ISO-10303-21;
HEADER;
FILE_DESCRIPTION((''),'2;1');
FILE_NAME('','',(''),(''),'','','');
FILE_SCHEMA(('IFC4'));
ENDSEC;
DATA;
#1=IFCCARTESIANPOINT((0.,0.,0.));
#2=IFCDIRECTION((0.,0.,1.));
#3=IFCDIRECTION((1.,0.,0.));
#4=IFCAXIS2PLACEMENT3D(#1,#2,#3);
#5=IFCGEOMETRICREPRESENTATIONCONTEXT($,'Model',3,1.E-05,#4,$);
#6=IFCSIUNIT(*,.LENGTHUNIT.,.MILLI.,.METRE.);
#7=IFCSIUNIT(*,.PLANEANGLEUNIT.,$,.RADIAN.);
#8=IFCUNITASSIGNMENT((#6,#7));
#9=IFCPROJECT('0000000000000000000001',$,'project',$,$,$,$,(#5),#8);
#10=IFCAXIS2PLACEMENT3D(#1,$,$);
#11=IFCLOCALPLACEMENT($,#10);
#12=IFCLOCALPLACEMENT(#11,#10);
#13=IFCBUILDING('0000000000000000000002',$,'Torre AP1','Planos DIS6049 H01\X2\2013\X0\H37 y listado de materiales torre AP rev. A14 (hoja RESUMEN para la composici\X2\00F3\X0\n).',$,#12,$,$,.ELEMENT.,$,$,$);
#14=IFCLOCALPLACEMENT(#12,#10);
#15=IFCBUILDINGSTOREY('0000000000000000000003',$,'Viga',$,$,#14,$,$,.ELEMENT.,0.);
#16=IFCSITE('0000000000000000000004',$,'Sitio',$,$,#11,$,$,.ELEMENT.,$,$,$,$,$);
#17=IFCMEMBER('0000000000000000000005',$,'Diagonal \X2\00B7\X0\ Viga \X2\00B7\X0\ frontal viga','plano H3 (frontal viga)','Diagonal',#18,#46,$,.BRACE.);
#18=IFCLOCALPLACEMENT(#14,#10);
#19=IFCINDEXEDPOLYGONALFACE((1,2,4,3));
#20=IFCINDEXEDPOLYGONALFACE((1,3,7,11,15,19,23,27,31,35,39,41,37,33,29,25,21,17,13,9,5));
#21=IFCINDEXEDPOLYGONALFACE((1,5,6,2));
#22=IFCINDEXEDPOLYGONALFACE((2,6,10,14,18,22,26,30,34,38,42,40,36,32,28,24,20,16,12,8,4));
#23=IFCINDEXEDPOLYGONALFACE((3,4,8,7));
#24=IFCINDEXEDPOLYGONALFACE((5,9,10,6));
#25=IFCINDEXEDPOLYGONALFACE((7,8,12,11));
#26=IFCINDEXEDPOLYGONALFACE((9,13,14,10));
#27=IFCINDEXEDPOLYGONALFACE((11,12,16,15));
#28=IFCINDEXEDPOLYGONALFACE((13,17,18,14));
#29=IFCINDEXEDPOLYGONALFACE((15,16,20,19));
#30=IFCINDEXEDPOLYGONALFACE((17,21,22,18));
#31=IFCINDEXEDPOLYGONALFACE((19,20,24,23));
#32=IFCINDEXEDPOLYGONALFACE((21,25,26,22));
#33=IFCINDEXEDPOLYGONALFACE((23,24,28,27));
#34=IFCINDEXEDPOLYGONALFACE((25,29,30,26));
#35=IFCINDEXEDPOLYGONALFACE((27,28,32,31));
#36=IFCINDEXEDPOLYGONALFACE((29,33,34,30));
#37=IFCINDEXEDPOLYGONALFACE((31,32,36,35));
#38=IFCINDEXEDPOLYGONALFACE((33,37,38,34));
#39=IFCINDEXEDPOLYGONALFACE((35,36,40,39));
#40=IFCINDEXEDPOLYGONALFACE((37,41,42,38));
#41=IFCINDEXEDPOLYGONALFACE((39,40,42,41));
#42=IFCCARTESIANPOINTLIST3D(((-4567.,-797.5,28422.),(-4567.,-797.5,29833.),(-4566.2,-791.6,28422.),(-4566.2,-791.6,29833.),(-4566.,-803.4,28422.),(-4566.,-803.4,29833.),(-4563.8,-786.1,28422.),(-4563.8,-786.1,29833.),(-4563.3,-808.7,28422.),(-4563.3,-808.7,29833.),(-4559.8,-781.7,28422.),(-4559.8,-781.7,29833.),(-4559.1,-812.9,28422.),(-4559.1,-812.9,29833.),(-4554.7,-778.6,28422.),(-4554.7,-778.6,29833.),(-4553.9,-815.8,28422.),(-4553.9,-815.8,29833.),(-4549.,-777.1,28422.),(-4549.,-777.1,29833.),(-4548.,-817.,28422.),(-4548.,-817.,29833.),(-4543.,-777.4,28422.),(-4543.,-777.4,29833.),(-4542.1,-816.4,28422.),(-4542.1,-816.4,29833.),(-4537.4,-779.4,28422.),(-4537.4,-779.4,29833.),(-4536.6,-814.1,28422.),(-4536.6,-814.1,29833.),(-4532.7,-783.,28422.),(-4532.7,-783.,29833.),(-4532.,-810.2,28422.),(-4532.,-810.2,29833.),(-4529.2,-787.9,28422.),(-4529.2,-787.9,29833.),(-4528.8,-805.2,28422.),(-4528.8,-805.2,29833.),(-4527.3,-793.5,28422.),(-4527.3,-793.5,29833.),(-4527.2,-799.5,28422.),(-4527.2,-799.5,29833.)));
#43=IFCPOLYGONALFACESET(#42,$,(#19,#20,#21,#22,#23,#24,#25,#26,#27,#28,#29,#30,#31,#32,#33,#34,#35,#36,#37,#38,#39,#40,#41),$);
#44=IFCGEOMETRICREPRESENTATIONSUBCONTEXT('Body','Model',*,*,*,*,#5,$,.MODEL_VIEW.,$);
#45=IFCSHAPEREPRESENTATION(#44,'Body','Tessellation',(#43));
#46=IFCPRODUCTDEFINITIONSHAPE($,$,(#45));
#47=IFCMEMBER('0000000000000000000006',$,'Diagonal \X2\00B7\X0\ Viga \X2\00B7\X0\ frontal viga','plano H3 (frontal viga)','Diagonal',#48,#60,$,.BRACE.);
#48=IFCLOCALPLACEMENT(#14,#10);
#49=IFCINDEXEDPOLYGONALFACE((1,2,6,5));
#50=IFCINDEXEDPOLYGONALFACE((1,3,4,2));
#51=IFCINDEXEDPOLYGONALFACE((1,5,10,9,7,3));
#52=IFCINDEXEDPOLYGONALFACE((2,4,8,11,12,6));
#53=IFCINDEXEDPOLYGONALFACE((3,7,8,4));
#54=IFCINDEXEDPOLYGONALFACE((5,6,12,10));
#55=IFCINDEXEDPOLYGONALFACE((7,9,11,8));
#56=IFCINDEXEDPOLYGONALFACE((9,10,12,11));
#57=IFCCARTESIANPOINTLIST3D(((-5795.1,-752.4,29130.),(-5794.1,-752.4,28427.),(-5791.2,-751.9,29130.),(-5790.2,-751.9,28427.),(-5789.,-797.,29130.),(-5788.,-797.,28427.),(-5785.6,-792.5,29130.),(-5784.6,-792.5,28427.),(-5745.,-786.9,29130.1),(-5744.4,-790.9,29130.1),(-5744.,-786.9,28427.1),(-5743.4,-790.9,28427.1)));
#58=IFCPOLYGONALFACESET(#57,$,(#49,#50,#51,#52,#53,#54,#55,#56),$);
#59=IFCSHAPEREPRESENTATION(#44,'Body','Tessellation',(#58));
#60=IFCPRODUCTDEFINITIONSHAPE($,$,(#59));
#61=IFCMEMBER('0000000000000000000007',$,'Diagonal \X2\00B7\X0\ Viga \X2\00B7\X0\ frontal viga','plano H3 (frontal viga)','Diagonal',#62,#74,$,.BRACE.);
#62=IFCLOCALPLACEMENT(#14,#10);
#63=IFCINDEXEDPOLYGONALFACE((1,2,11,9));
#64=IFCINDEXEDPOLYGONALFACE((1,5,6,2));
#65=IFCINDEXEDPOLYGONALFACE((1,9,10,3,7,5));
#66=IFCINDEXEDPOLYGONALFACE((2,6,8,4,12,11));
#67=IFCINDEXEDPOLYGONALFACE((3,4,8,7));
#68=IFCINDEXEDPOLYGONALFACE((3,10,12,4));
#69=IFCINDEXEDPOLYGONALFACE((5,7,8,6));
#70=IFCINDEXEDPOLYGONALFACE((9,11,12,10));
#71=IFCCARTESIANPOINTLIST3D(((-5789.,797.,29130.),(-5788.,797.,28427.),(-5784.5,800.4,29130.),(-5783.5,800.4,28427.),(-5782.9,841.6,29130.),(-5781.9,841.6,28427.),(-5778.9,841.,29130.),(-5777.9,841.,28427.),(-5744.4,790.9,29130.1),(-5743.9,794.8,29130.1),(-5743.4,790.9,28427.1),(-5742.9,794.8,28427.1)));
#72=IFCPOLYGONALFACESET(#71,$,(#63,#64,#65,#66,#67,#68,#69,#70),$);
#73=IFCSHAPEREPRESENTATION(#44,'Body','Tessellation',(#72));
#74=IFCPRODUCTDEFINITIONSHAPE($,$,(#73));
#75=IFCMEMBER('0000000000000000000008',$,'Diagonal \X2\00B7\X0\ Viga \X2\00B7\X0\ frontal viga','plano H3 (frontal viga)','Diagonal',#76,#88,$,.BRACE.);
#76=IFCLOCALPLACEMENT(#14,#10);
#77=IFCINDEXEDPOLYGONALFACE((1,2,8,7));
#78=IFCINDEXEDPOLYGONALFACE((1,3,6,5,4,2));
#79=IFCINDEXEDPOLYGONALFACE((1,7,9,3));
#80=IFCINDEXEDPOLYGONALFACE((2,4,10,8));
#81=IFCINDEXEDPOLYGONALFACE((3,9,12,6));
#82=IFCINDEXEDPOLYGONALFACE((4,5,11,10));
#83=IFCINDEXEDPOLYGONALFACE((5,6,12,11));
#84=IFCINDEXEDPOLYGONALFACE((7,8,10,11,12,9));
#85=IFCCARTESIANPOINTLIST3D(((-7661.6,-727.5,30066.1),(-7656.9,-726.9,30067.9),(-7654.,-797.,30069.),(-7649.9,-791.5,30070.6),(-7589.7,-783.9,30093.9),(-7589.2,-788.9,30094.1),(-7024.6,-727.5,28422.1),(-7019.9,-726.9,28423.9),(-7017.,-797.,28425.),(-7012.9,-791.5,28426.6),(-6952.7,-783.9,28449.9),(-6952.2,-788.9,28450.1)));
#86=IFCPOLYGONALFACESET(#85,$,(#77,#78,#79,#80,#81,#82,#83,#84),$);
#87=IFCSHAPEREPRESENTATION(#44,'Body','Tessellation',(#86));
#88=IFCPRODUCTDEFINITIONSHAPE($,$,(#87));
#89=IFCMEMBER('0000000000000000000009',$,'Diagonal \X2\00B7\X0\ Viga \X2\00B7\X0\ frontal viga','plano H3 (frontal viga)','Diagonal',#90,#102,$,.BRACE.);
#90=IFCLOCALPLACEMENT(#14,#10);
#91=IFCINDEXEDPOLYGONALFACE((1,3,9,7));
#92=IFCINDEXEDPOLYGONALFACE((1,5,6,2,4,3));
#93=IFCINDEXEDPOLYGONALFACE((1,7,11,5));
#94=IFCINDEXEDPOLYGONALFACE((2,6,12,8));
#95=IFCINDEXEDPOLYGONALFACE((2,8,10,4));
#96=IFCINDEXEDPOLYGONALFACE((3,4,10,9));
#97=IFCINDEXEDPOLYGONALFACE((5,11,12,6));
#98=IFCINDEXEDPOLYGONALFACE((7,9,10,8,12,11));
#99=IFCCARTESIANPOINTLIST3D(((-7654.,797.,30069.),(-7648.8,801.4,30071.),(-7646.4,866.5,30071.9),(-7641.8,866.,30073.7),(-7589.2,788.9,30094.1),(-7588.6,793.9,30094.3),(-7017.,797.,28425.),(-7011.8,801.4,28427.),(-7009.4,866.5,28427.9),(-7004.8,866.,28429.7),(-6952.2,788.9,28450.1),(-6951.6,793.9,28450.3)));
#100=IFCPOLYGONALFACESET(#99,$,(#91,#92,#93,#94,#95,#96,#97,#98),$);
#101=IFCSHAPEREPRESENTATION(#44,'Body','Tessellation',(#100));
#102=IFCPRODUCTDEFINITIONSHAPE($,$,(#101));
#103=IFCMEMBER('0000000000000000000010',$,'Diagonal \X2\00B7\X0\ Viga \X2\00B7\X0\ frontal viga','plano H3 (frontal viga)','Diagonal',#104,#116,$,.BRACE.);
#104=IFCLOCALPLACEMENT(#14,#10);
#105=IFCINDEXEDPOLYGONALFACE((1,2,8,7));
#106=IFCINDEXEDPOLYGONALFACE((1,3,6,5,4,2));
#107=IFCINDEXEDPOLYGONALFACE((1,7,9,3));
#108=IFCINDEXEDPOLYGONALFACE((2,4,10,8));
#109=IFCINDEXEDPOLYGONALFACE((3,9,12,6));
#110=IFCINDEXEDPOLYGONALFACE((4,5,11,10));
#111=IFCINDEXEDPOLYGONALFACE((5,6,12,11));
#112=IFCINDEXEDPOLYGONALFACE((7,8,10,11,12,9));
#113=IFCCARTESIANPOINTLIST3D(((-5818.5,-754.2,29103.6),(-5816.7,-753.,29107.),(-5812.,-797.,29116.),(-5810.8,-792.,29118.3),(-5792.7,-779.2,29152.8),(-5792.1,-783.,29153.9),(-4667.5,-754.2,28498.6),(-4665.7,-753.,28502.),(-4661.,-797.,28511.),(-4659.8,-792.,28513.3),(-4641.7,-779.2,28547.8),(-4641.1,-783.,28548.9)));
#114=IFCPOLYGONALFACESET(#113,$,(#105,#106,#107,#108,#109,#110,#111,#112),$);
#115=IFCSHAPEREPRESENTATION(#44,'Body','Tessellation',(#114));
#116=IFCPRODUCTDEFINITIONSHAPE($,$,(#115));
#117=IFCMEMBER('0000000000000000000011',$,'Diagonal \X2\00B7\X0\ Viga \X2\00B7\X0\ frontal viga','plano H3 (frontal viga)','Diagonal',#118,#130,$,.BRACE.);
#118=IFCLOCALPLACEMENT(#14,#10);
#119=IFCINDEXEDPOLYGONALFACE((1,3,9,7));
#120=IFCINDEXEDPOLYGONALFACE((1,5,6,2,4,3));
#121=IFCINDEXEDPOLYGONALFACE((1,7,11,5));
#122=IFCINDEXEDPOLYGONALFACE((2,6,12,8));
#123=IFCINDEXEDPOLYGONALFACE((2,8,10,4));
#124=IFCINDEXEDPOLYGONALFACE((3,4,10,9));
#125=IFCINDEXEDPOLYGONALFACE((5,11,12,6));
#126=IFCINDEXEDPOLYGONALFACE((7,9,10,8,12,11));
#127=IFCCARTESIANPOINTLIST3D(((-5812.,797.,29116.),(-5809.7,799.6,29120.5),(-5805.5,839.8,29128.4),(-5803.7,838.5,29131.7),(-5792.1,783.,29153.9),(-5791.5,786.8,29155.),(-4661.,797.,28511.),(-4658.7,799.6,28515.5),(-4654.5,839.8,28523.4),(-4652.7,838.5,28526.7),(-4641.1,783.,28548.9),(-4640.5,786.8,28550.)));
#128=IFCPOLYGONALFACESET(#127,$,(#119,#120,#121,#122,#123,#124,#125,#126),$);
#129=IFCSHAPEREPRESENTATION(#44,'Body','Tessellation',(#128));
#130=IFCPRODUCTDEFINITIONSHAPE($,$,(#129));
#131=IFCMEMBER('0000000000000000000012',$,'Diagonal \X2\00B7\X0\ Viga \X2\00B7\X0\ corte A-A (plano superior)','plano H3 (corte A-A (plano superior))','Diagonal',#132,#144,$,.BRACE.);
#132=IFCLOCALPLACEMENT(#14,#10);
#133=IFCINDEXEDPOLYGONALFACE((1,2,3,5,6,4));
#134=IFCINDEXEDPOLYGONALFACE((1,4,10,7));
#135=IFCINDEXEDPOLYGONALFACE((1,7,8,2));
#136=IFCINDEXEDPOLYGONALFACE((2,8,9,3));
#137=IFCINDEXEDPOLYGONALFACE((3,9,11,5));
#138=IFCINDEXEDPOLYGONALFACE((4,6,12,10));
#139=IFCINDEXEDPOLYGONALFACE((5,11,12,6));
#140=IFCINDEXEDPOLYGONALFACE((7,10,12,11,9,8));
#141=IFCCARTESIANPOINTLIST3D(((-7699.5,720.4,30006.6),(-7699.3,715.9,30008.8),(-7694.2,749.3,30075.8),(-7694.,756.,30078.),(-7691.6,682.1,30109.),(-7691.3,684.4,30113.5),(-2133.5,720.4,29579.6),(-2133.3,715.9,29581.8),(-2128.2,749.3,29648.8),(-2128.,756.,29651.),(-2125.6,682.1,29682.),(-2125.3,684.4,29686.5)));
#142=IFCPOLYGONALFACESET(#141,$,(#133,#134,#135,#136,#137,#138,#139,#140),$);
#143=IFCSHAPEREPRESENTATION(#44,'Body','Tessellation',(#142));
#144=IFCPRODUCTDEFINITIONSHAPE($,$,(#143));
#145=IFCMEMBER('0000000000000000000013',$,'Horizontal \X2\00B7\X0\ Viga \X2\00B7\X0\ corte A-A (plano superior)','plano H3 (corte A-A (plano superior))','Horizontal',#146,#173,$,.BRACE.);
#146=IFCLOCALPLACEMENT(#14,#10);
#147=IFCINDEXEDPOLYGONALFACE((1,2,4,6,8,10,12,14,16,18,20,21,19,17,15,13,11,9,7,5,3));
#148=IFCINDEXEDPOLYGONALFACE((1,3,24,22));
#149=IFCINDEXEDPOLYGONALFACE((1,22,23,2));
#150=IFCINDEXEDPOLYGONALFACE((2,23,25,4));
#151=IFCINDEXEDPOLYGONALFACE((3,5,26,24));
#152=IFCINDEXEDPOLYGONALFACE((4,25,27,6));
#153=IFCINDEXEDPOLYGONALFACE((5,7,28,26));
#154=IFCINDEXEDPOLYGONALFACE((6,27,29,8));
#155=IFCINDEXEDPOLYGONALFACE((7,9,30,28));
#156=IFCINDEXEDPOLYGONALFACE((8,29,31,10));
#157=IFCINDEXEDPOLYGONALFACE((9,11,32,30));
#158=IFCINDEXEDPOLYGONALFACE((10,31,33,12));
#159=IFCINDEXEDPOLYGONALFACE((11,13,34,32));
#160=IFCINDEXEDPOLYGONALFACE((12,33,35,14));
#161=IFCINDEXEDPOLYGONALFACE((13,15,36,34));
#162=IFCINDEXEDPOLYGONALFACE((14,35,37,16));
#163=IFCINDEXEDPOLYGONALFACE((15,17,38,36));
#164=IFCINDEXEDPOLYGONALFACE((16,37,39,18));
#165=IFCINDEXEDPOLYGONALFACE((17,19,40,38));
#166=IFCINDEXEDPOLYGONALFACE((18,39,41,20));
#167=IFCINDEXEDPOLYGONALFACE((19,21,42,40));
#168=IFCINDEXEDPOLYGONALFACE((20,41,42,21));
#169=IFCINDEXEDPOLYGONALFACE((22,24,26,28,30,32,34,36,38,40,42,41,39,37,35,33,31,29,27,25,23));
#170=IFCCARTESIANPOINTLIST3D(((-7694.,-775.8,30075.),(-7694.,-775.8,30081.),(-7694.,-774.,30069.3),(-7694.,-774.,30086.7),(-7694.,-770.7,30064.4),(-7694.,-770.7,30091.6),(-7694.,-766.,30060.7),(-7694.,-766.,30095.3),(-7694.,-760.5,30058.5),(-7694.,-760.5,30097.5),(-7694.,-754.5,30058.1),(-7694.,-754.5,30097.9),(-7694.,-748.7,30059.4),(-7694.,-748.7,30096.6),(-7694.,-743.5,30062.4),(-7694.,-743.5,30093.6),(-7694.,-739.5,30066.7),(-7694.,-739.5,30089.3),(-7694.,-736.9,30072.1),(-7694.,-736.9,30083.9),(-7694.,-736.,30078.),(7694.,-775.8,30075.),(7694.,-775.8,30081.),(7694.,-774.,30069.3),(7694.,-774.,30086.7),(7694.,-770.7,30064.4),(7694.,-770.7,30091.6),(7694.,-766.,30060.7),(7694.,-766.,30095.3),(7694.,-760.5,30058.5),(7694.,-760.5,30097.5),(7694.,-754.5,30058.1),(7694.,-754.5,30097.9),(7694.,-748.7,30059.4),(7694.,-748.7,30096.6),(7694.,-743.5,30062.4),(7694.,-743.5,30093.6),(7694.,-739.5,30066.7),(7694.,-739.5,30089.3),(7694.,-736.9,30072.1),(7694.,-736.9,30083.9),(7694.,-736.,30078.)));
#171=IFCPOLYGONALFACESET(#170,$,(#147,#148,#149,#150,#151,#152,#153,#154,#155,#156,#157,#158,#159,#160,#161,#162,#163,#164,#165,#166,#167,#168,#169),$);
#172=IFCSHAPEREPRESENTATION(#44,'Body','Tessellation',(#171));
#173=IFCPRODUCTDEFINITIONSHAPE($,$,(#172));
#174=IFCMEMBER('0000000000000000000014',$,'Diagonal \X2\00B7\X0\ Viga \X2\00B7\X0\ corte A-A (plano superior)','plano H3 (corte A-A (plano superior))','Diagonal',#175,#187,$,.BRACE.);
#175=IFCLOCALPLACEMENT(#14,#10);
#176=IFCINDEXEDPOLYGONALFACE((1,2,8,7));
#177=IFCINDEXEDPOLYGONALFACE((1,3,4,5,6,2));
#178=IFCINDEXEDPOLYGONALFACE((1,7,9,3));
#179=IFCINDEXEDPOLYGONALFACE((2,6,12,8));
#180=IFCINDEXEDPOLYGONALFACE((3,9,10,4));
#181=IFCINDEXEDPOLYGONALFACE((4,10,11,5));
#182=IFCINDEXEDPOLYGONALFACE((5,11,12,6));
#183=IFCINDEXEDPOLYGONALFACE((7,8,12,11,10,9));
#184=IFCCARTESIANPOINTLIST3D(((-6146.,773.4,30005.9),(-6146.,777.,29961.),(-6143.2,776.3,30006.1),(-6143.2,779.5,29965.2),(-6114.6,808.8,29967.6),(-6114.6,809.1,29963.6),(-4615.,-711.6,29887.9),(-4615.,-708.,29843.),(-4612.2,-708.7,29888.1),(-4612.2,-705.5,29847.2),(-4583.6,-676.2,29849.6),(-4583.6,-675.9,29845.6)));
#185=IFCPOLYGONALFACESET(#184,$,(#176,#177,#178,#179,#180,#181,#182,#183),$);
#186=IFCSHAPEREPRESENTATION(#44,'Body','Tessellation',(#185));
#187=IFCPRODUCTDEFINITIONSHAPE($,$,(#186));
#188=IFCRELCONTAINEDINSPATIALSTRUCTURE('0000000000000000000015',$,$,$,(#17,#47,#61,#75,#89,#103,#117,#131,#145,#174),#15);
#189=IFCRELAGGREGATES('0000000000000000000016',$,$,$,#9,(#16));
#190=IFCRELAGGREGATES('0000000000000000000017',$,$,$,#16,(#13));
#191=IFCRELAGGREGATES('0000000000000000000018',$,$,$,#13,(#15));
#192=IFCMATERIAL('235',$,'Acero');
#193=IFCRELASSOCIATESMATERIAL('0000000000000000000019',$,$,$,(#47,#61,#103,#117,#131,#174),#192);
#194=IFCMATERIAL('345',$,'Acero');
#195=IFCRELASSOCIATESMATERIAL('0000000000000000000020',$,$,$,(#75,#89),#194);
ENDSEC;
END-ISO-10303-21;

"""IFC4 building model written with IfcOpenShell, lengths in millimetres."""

from ifc_helpers import new_model, si_unit, frame, frame_2d, origin, origin_with_axes, place, context, subcontext, project, spatial, circle, l_section, extrude, material, element, save


model = new_model("IFC4")

# Units and contexts
model_context = context("Model", 3, precision=1e-05, world=origin_with_axes())
body_context = subcontext(model_context, "Body", "Model", "MODEL_VIEW")
ifc_project = project(units=[si_unit("LENGTHUNIT", "METRE", prefix="MILLI"), si_unit("PLANEANGLEUNIT", "RADIAN")], contexts=[model_context])

# Site, building, storey
site_placement = place(None, origin())
site = spatial("IfcSite", under=ifc_project, at=site_placement, Name="Sitio", CompositionType="ELEMENT")
building_placement = place(site_placement, origin())
building = spatial("IfcBuilding", under=site, at=building_placement, Name="Torre AP1", Description="Planos DIS6049 H01–H37 y listado de materiales torre AP rev. A14 (hoja RESUMEN para la composición).", CompositionType="ELEMENT")
storey_placement = place(building_placement, origin())
storey = spatial("IfcBuildingStorey", under=building, at=storey_placement, Name="Viga", CompositionType="ELEMENT", Elevation=0.0)

# Members
ifc_material_1 = material(Name="345", Category="Acero")
member_1_placement = place(storey_placement, frame((-4547.0, -797.0, 28422.0), z_axis=(0.0, 0.0, 1.0), x_axis=(0.984984, 0.172648, 0.0)))
element("IfcMember", 1, at=member_1_placement, inside=storey, Name="Diagonal · Viga · frontal viga", Description="plano H3 (frontal viga)", ObjectType="Diagonal", PredefinedType="BRACE", context=body_context, shape_type="SweptSolid", body=[
    extrude(circle(Radius=20.0), None, (0.0, 0.0, 1.0), 1411.0),
])
ifc_material_2 = material(Name="235", Category="Acero")
for number, where, z_axis, x_axis, name in (
    (2, (-5788.0, -797.0, 28427.0), (-0.001422, 0.0, 0.999999), (0.990653, 0.1364, 0.001409), "Diagonal · Viga · frontal viga"),
    (3, (-5788.0, 797.0, 28427.0), (-0.001422, 0.0, 0.999999), (0.990653, -0.1364, 0.001409), "Diagonal · Viga · frontal viga"),
):
    element("IfcMember", number, at=place(storey_placement, frame(where, z_axis=z_axis, x_axis=x_axis)), inside=storey, material=ifc_material_2, Name=name, Description="plano H3 (frontal viga)", ObjectType="Diagonal", PredefinedType="BRACE", context=body_context, shape_type="SweptSolid", body=[
        extrude(l_section(Depth=45.0, Width=45.0, Thickness=4.0, at=frame_2d((22.5, 22.5))), None, (0.0, 0.0, 1.0), 703.0),
    ])
for number, where, z_axis, x_axis, name in (
    (4, (-7017.0, -797.0, 28425.0), (-0.361296, 0.0, 0.932451), (0.926185, 0.115738, 0.358868), "Diagonal · Viga · frontal viga"),
    (5, (-7017.0, 797.0, 28425.0), (-0.361296, 0.0, 0.932451), (0.926185, -0.115738, 0.358868), "Diagonal · Viga · frontal viga"),
):
    element("IfcMember", number, at=place(storey_placement, frame(where, z_axis=z_axis, x_axis=x_axis)), inside=storey, material=ifc_material_1, Name=name, Description="plano H3 (frontal viga)", ObjectType="Diagonal", PredefinedType="BRACE", context=body_context, shape_type="SweptSolid", body=[
        extrude(l_section(Depth=70.0, Width=70.0, Thickness=5.0, at=frame_2d((35.0, 35.0))), None, (0.0, 0.0, 1.0), 1763.1),
    ])
for number, where, z_axis, x_axis, name in (
    (6, (-4661.0, -797.0, 28511.0), (-0.885168, 0.0, 0.465271), (0.442212, 0.310911, 0.841299), "Diagonal · Viga · frontal viga"),
    (7, (-4661.0, 797.0, 28511.0), (-0.885168, 0.0, 0.465271), (0.442212, -0.310911, 0.841299), "Diagonal · Viga · frontal viga"),
):
    element("IfcMember", number, at=place(storey_placement, frame(where, z_axis=z_axis, x_axis=x_axis)), inside=storey, material=ifc_material_2, Name=name, Description="plano H3 (frontal viga)", ObjectType="Diagonal", PredefinedType="BRACE", context=body_context, shape_type="SweptSolid", body=[
        extrude(l_section(Depth=45.0, Width=45.0, Thickness=4.0, at=frame_2d((22.5, 22.5))), None, (0.0, 0.0, 1.0), 1300.3),
    ])
member_2_placement = place(storey_placement, frame((-7694.0, 756.0, 30078.0), z_axis=(0.99707, 0.0, -0.076491), x_axis=(0.034037, -0.895539, 0.443679)))
element("IfcMember", 8, at=member_2_placement, inside=storey, material=ifc_material_2, Name="Diagonal · Viga · corte A-A (plano superior)", Description="plano H3 (corte A-A (plano superior))", ObjectType="Diagonal", PredefinedType="BRACE", context=body_context, shape_type="SweptSolid", body=[
    extrude(l_section(Depth=80.0, Width=80.0, Thickness=5.0, at=frame_2d((40.0, 40.0))), None, (0.0, 0.0, 1.0), 5582.4),
])
member_3_placement = place(storey_placement, frame((-7694.0, -756.0, 30078.0), z_axis=(1.0, 0.0, 0.0), x_axis=(0.0, 1.0, 0.0)))
element("IfcMember", 9, at=member_3_placement, inside=storey, Name="Horizontal · Viga · corte A-A (plano superior)", Description="plano H3 (corte A-A (plano superior))", ObjectType="Horizontal", PredefinedType="BRACE", context=body_context, shape_type="SweptSolid", body=[
    extrude(circle(Radius=20.0), None, (0.0, 0.0, 1.0), 15388.0),
])
member_4_placement = place(storey_placement, frame((-6146.0, 777.0, 29961.0), z_axis=(0.716712, -0.695178, -0.05524), x_axis=(0.697369, 0.714402, 0.057503)))
element("IfcMember", 10, at=member_4_placement, inside=storey, material=ifc_material_2, Name="Diagonal · Viga · corte A-A (plano superior)", Description="plano H3 (corte A-A (plano superior))", ObjectType="Diagonal", PredefinedType="BRACE", context=body_context, shape_type="SweptSolid", body=[
    extrude(l_section(Depth=45.0, Width=45.0, Thickness=4.0, at=frame_2d((22.5, 22.5))), None, (0.0, 0.0, 1.0), 2136.1),
])

save(model, "model.ifc")
